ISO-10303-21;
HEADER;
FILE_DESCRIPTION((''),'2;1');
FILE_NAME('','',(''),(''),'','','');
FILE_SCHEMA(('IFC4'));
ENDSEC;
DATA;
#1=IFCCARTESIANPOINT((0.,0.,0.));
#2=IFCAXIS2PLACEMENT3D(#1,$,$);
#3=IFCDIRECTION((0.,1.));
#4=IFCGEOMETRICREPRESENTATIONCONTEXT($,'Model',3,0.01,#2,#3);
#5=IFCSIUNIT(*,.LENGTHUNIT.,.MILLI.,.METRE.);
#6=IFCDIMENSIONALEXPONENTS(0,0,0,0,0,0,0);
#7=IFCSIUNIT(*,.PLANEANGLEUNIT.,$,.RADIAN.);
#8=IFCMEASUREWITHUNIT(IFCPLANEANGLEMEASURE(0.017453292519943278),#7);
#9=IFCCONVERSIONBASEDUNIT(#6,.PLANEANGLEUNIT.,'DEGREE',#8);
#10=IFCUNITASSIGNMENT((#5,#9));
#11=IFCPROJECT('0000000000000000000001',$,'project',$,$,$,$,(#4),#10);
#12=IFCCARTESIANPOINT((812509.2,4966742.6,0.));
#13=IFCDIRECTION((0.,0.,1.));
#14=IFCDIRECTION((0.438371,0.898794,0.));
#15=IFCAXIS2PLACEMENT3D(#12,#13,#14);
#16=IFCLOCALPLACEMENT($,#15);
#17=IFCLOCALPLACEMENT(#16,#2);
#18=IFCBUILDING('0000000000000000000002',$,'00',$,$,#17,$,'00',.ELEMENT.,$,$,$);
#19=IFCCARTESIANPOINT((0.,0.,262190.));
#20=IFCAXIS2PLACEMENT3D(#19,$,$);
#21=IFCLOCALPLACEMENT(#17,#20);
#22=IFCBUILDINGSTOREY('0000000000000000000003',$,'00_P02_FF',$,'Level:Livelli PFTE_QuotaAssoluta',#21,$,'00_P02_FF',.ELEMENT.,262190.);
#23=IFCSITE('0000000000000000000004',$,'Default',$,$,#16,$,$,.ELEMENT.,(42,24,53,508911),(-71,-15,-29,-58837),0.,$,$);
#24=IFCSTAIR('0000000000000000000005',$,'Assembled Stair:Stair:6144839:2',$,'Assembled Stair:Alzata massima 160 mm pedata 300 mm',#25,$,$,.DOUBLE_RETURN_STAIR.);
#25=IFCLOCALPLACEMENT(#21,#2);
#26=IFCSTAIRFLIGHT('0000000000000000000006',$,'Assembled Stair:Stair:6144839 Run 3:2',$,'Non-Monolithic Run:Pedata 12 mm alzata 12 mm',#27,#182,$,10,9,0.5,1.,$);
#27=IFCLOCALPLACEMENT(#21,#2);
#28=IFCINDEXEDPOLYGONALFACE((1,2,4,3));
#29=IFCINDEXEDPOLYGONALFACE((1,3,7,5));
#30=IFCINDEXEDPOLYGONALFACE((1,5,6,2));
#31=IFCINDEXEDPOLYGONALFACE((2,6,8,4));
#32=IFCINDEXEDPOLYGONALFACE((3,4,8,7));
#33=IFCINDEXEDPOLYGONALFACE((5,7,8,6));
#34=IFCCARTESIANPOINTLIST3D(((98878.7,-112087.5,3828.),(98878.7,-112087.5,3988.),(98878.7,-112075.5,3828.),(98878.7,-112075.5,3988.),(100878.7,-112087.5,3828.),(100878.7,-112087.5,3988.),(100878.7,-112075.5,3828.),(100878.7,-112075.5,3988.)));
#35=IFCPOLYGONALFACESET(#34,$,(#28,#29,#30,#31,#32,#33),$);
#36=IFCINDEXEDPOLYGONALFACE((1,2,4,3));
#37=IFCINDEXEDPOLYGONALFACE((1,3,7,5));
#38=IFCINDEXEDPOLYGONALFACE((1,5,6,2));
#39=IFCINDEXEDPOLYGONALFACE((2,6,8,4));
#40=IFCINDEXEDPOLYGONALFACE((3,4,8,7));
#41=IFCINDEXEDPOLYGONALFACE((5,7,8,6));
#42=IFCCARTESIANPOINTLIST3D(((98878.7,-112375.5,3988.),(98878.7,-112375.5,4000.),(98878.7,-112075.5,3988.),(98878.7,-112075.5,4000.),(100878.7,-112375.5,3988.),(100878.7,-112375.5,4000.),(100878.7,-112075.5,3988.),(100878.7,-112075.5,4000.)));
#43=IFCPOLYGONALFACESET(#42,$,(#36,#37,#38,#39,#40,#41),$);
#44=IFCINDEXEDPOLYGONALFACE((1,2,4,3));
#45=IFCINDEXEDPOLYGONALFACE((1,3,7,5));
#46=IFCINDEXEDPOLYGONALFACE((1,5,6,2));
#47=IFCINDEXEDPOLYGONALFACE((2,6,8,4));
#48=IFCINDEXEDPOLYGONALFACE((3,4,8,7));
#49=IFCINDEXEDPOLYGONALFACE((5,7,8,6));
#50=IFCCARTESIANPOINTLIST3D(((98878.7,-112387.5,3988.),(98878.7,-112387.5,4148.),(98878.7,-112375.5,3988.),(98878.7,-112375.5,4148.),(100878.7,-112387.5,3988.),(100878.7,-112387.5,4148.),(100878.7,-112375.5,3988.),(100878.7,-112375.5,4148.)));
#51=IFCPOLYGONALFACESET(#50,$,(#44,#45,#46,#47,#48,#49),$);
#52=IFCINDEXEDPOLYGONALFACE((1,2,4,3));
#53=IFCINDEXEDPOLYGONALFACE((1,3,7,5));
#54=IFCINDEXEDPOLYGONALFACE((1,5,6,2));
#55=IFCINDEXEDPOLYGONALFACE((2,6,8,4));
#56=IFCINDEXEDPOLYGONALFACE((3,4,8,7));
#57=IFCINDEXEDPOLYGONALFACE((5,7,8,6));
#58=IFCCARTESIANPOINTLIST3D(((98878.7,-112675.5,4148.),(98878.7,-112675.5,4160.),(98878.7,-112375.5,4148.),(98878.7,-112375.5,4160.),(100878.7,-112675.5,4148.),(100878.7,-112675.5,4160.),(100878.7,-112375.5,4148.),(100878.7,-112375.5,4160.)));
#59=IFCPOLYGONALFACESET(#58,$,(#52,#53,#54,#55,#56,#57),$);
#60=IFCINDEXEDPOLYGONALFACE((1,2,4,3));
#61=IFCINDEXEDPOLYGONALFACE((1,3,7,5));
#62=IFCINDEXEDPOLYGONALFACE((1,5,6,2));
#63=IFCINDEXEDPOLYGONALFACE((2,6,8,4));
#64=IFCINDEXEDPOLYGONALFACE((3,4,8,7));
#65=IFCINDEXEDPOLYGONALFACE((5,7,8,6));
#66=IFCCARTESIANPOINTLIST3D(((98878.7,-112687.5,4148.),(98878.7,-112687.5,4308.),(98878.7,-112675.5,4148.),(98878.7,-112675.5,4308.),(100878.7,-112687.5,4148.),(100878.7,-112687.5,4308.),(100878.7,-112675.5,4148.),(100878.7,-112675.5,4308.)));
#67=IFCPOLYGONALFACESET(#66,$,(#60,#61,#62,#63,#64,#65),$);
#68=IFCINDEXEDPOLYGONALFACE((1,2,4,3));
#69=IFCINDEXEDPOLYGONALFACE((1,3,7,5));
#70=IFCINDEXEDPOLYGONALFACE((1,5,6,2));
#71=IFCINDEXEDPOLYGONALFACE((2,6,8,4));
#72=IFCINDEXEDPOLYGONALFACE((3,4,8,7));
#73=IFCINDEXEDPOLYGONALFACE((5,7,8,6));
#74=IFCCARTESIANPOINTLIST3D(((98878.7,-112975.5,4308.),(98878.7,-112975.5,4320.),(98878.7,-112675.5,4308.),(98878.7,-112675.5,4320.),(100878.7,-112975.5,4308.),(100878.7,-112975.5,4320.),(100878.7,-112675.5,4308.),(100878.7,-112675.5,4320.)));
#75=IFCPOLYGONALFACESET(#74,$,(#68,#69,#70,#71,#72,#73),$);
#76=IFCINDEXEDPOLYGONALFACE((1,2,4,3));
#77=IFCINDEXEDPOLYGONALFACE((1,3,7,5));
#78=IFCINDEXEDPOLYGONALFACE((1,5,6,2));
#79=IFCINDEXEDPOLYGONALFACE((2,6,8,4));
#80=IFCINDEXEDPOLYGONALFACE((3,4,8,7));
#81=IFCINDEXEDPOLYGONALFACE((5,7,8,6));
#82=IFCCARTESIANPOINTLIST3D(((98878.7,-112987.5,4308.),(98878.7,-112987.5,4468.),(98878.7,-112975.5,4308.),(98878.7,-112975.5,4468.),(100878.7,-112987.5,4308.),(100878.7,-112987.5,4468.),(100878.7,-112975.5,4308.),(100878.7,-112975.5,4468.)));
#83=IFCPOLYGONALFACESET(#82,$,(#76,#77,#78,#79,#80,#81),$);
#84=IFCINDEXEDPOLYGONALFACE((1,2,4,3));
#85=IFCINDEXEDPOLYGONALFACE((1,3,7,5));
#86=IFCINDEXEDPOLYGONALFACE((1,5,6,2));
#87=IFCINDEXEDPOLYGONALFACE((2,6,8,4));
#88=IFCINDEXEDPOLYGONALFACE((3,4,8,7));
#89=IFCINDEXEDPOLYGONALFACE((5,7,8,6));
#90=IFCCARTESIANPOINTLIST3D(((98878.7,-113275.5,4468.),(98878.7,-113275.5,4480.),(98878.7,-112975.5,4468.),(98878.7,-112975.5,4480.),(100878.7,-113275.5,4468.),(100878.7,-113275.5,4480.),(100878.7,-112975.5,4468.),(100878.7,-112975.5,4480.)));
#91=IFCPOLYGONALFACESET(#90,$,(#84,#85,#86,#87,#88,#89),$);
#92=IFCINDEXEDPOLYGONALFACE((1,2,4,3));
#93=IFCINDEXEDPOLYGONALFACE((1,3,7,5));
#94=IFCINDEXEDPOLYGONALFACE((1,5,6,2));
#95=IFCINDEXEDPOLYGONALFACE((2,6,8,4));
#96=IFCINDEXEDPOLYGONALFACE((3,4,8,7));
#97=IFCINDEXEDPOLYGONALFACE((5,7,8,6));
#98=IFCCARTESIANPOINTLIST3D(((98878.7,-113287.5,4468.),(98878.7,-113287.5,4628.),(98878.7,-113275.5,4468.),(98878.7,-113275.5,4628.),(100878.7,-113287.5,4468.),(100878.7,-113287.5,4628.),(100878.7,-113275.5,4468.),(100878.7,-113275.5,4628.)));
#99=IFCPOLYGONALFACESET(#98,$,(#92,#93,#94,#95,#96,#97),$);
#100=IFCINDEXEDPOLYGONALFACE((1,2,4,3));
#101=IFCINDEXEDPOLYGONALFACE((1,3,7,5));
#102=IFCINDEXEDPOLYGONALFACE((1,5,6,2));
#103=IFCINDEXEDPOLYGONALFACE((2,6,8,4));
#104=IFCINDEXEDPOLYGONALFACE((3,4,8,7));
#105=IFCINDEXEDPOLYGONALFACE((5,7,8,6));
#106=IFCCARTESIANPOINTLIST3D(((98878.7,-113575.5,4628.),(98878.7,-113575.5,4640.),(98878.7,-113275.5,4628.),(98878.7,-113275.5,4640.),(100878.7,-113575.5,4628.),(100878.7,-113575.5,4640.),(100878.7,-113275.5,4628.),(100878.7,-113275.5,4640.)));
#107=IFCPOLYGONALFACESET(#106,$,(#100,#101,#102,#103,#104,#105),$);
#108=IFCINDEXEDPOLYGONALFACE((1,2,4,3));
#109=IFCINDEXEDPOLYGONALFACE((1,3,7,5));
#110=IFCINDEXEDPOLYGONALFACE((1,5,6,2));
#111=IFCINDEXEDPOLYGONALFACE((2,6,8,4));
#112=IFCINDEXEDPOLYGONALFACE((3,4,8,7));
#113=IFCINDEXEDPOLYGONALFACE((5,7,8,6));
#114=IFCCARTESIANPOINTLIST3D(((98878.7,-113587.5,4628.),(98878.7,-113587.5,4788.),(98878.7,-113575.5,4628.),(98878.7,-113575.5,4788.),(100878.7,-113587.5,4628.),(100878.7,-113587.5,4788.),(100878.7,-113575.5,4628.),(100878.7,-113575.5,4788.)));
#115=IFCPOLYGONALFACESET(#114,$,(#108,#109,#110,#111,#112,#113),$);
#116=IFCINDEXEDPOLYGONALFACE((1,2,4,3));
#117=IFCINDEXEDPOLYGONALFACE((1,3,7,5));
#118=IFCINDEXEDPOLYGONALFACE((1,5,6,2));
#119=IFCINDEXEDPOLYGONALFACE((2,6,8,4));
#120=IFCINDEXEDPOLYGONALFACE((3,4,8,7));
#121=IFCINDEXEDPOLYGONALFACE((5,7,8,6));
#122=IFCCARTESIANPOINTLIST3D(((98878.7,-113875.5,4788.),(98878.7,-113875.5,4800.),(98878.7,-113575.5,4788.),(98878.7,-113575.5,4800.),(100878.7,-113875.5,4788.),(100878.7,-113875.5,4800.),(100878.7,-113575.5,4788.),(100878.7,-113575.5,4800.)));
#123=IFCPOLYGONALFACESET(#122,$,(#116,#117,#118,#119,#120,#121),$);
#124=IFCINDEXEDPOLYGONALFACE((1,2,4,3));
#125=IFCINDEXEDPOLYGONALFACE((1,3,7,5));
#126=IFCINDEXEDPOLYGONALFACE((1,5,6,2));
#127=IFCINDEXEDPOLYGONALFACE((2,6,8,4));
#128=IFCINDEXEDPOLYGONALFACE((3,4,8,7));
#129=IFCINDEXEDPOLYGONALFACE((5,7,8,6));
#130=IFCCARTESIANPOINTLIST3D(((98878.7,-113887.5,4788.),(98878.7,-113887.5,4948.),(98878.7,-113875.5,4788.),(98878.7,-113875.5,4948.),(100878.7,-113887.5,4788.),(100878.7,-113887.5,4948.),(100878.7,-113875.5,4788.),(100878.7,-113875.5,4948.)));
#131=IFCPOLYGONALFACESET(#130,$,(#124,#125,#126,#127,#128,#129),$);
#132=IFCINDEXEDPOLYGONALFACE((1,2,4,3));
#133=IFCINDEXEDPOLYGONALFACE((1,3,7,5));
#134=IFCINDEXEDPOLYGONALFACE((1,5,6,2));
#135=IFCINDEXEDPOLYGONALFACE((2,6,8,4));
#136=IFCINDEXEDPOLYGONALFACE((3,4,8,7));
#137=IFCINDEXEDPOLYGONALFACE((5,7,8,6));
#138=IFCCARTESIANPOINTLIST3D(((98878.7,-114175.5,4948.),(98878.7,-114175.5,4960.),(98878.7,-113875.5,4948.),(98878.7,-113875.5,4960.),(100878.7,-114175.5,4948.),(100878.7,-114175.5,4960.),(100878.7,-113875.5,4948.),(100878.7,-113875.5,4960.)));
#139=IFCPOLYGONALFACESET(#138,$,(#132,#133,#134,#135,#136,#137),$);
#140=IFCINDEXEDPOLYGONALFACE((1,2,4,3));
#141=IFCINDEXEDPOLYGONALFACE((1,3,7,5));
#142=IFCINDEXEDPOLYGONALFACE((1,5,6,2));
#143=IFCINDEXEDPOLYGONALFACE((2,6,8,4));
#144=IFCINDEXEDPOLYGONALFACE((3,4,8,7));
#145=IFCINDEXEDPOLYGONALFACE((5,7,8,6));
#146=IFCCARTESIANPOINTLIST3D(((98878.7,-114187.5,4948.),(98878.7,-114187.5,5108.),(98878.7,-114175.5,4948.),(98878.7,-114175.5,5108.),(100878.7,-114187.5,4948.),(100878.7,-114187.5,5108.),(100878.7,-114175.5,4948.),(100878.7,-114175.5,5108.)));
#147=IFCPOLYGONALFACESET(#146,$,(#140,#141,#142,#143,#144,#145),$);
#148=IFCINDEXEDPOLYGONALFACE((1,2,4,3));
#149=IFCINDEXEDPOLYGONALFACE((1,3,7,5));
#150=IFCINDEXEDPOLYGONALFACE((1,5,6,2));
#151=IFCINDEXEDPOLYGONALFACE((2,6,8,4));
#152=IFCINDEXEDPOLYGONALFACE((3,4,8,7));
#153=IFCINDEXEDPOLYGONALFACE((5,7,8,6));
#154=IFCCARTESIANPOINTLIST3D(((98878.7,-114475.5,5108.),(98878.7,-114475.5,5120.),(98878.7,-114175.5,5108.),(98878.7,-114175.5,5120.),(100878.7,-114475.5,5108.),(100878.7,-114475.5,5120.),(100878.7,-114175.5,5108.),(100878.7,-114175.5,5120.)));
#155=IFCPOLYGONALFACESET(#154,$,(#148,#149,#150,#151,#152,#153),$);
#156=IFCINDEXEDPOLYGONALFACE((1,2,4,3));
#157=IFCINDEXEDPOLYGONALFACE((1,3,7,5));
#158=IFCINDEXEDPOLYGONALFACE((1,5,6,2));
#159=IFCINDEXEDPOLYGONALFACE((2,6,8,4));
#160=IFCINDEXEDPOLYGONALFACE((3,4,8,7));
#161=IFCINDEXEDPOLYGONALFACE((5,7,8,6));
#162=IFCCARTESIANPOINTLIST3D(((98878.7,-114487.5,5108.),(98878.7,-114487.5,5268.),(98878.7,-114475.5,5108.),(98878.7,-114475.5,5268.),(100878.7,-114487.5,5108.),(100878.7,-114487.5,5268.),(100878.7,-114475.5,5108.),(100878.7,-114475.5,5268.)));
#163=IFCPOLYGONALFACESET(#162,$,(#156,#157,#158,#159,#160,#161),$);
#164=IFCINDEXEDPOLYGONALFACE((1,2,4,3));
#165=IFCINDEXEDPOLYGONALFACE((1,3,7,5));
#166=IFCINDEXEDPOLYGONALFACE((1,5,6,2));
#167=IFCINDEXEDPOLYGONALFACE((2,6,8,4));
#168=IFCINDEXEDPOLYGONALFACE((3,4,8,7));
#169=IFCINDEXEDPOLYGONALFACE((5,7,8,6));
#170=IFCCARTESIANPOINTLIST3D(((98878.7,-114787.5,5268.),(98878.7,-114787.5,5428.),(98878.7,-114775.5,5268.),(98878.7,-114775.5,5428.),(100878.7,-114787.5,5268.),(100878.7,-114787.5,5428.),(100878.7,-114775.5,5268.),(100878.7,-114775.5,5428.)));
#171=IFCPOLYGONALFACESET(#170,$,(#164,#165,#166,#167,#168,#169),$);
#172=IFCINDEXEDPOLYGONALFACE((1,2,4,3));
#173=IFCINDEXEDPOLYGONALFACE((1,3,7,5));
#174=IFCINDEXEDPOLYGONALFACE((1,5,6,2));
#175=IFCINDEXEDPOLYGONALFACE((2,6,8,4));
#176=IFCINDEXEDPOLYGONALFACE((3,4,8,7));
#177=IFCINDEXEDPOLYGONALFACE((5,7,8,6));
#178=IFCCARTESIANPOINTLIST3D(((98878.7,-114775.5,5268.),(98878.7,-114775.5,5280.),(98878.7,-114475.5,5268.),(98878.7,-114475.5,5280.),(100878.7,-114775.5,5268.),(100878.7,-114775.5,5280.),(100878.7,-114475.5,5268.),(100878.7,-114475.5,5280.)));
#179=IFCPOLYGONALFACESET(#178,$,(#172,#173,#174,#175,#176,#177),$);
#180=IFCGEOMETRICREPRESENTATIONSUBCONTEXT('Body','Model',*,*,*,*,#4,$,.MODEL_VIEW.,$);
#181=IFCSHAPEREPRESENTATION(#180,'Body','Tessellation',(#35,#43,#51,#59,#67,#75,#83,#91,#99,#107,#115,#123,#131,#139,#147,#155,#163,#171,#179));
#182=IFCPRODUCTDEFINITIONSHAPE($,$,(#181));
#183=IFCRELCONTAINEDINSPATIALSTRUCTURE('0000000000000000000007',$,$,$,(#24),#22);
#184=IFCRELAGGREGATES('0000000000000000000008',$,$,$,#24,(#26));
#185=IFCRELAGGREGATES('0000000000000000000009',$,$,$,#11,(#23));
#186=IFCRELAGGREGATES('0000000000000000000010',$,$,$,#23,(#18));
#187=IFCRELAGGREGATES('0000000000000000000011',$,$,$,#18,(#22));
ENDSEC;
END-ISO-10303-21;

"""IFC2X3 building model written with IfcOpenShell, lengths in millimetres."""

from ifc_helpers import new_model, entity, si_unit, converted_unit, direction, frame, frame_2d, origin, origin_2d_with_axis, place, context, subcontext, project, spatial, rectangle, extrude, element, aggregate, save


model = new_model("IFC2X3")

# Units and contexts
model_context = context("Model", 3, precision=0.01, world=origin(), true_north=direction((0.0, 1.0)))
body_context = subcontext(model_context, "Body", "Model", "MODEL_VIEW")
ifc_project = project(units=[si_unit("LENGTHUNIT", "METRE", prefix="MILLI"), converted_unit("PLANEANGLEUNIT", "DEGREE", entity("IfcPlaneAngleMeasure", 0.017453292519943278), si_unit("PLANEANGLEUNIT", "RADIAN"), dimensions=[0, 0, 0, 0, 0, 0, 0])], contexts=[model_context])

# Site, building, storey
site_placement = place(None, frame((812509.2, 4966742.6, 0.0), z_axis=(0.0, 0.0, 1.0), x_axis=(0.438371, 0.898794, 0.0)))
site = spatial("IfcSite", under=ifc_project, at=site_placement, Name="Default", CompositionType="ELEMENT", RefLatitude=(42, 24, 53, 508911), RefLongitude=(-71, -15, -29, -58837), RefElevation=0.0)
building_placement = place(site_placement, origin())
building = spatial("IfcBuilding", under=site, at=building_placement, Name="00", LongName="00", CompositionType="ELEMENT")
storey_placement = place(building_placement, frame((0.0, 0.0, 262190.0)))
storey = spatial("IfcBuildingStorey", under=building, at=storey_placement, Name="00_P02_FF", ObjectType="Level:Livelli PFTE_QuotaAssoluta", LongName="00_P02_FF", CompositionType="ELEMENT", Elevation=262190.0)

# Stair
stair_1_placement = place(storey_placement, origin())
stair_1 = element("IfcStair", 1, at=stair_1_placement, inside=storey, Name="Assembled Stair:Stair:6144839:2", ObjectType="Assembled Stair:Alzata massima 160 mm pedata 300 mm", ShapeType="DOUBLE_RETURN_STAIR")

# Stair flight
stair_flight_1_placement = place(stair_1_placement, origin())
stair_flight_1 = element("IfcStairFlight", 2, at=stair_flight_1_placement, Name="Assembled Stair:Stair:6144839 Run 3:2", ObjectType="Non-Monolithic Run:Pedata 12 mm alzata 12 mm", NumberOfRiser=10, NumberOfTreads=9, RiserHeight=0.5, TreadLength=1.0, context=body_context, shape_type="SweptSolid", body=[
    extrude(rectangle(XDim=2000.0, YDim=12.0, at=origin_2d_with_axis()), frame((99878.7, -112081.5, 3828.0)), (0.0, 0.0, 1.0), 160.0),
    extrude(rectangle(XDim=300.0, YDim=2000.0, at=origin_2d_with_axis()), frame((99878.7, -112225.5, 3988.0), z_axis=(0.0, 0.0, 1.0), x_axis=(0.0, 1.0, 0.0)), (0.0, 0.0, 1.0), 12.0),
    extrude(rectangle(XDim=2000.0, YDim=12.0, at=origin_2d_with_axis()), frame((99878.7, -112381.5, 3988.0)), (0.0, 0.0, 1.0), 160.0),
    extrude(rectangle(XDim=300.0, YDim=2000.0, at=frame_2d((0.0, 0.0), x_axis=(1.0, 0.0))), frame((99878.7, -112525.5, 4148.0), z_axis=(0.0, 0.0, 1.0), x_axis=(0.0, 1.0, 0.0)), (0.0, 0.0, 1.0), 12.0),
    extrude(rectangle(XDim=2000.0, YDim=12.0, at=origin_2d_with_axis()), frame((99878.7, -112681.5, 4148.0)), (0.0, 0.0, 1.0), 160.0),
    extrude(rectangle(XDim=300.0, YDim=2000.0, at=frame_2d((0.0, 0.0), x_axis=(1.0, 0.0))), frame((99878.7, -112825.5, 4308.0), z_axis=(0.0, 0.0, 1.0), x_axis=(0.0, 1.0, 0.0)), (0.0, 0.0, 1.0), 12.0),
    extrude(rectangle(XDim=2000.0, YDim=12.0, at=origin_2d_with_axis()), frame((99878.7, -112981.5, 4308.0)), (0.0, 0.0, 1.0), 160.0),
    extrude(rectangle(XDim=300.0, YDim=2000.0, at=frame_2d((0.0, 0.0), x_axis=(1.0, 0.0))), frame((99878.7, -113125.5, 4468.0), z_axis=(0.0, 0.0, 1.0), x_axis=(0.0, 1.0, 0.0)), (0.0, 0.0, 1.0), 12.0),
    extrude(rectangle(XDim=2000.0, YDim=12.0, at=origin_2d_with_axis()), frame((99878.7, -113281.5, 4468.0)), (0.0, 0.0, 1.0), 160.0),
    extrude(rectangle(XDim=300.0, YDim=2000.0, at=frame_2d((0.0, 0.0), x_axis=(1.0, 0.0))), frame((99878.7, -113425.5, 4628.0), z_axis=(0.0, 0.0, 1.0), x_axis=(0.0, 1.0, 0.0)), (0.0, 0.0, 1.0), 12.0),
    extrude(rectangle(XDim=2000.0, YDim=12.0, at=origin_2d_with_axis()), frame((99878.7, -113581.5, 4628.0)), (0.0, 0.0, 1.0), 160.0),
    extrude(rectangle(XDim=300.0, YDim=2000.0, at=frame_2d((0.0, 0.0), x_axis=(1.0, 0.0))), frame((99878.7, -113725.5, 4788.0), z_axis=(0.0, 0.0, 1.0), x_axis=(0.0, 1.0, 0.0)), (0.0, 0.0, 1.0), 12.0),
    extrude(rectangle(XDim=2000.0, YDim=12.0, at=origin_2d_with_axis()), frame((99878.7, -113881.5, 4788.0)), (0.0, 0.0, 1.0), 160.0),
    extrude(rectangle(XDim=300.0, YDim=2000.0, at=frame_2d((0.0, 0.0), x_axis=(1.0, 0.0))), frame((99878.7, -114025.5, 4948.0), z_axis=(0.0, 0.0, 1.0), x_axis=(0.0, 1.0, 0.0)), (0.0, 0.0, 1.0), 12.0),
    extrude(rectangle(XDim=2000.0, YDim=12.0, at=origin_2d_with_axis()), frame((99878.7, -114181.5, 4948.0)), (0.0, 0.0, 1.0), 160.0),
    extrude(rectangle(XDim=300.0, YDim=2000.0, at=frame_2d((0.0, 0.0), x_axis=(1.0, 0.0))), frame((99878.7, -114325.5, 5108.0), z_axis=(0.0, 0.0, 1.0), x_axis=(0.0, 1.0, 0.0)), (0.0, 0.0, 1.0), 12.0),
    extrude(rectangle(XDim=2000.0, YDim=12.0, at=origin_2d_with_axis()), frame((99878.7, -114481.5, 5108.0)), (0.0, 0.0, 1.0), 160.0),
    extrude(rectangle(XDim=2000.0, YDim=12.0, at=origin_2d_with_axis()), frame((99878.7, -114781.5, 5268.0)), (0.0, 0.0, 1.0), 160.0),
    extrude(rectangle(XDim=300.0, YDim=2000.0, at=frame_2d((0.0, 0.0), x_axis=(1.0, 0.0))), frame((99878.7, -114625.5, 5268.0), z_axis=(0.0, 0.0, 1.0), x_axis=(0.0, 1.0, 0.0)), (0.0, 0.0, 1.0), 12.0),
])
aggregate(stair_1, [stair_flight_1])

save(model, "model.ifc")
